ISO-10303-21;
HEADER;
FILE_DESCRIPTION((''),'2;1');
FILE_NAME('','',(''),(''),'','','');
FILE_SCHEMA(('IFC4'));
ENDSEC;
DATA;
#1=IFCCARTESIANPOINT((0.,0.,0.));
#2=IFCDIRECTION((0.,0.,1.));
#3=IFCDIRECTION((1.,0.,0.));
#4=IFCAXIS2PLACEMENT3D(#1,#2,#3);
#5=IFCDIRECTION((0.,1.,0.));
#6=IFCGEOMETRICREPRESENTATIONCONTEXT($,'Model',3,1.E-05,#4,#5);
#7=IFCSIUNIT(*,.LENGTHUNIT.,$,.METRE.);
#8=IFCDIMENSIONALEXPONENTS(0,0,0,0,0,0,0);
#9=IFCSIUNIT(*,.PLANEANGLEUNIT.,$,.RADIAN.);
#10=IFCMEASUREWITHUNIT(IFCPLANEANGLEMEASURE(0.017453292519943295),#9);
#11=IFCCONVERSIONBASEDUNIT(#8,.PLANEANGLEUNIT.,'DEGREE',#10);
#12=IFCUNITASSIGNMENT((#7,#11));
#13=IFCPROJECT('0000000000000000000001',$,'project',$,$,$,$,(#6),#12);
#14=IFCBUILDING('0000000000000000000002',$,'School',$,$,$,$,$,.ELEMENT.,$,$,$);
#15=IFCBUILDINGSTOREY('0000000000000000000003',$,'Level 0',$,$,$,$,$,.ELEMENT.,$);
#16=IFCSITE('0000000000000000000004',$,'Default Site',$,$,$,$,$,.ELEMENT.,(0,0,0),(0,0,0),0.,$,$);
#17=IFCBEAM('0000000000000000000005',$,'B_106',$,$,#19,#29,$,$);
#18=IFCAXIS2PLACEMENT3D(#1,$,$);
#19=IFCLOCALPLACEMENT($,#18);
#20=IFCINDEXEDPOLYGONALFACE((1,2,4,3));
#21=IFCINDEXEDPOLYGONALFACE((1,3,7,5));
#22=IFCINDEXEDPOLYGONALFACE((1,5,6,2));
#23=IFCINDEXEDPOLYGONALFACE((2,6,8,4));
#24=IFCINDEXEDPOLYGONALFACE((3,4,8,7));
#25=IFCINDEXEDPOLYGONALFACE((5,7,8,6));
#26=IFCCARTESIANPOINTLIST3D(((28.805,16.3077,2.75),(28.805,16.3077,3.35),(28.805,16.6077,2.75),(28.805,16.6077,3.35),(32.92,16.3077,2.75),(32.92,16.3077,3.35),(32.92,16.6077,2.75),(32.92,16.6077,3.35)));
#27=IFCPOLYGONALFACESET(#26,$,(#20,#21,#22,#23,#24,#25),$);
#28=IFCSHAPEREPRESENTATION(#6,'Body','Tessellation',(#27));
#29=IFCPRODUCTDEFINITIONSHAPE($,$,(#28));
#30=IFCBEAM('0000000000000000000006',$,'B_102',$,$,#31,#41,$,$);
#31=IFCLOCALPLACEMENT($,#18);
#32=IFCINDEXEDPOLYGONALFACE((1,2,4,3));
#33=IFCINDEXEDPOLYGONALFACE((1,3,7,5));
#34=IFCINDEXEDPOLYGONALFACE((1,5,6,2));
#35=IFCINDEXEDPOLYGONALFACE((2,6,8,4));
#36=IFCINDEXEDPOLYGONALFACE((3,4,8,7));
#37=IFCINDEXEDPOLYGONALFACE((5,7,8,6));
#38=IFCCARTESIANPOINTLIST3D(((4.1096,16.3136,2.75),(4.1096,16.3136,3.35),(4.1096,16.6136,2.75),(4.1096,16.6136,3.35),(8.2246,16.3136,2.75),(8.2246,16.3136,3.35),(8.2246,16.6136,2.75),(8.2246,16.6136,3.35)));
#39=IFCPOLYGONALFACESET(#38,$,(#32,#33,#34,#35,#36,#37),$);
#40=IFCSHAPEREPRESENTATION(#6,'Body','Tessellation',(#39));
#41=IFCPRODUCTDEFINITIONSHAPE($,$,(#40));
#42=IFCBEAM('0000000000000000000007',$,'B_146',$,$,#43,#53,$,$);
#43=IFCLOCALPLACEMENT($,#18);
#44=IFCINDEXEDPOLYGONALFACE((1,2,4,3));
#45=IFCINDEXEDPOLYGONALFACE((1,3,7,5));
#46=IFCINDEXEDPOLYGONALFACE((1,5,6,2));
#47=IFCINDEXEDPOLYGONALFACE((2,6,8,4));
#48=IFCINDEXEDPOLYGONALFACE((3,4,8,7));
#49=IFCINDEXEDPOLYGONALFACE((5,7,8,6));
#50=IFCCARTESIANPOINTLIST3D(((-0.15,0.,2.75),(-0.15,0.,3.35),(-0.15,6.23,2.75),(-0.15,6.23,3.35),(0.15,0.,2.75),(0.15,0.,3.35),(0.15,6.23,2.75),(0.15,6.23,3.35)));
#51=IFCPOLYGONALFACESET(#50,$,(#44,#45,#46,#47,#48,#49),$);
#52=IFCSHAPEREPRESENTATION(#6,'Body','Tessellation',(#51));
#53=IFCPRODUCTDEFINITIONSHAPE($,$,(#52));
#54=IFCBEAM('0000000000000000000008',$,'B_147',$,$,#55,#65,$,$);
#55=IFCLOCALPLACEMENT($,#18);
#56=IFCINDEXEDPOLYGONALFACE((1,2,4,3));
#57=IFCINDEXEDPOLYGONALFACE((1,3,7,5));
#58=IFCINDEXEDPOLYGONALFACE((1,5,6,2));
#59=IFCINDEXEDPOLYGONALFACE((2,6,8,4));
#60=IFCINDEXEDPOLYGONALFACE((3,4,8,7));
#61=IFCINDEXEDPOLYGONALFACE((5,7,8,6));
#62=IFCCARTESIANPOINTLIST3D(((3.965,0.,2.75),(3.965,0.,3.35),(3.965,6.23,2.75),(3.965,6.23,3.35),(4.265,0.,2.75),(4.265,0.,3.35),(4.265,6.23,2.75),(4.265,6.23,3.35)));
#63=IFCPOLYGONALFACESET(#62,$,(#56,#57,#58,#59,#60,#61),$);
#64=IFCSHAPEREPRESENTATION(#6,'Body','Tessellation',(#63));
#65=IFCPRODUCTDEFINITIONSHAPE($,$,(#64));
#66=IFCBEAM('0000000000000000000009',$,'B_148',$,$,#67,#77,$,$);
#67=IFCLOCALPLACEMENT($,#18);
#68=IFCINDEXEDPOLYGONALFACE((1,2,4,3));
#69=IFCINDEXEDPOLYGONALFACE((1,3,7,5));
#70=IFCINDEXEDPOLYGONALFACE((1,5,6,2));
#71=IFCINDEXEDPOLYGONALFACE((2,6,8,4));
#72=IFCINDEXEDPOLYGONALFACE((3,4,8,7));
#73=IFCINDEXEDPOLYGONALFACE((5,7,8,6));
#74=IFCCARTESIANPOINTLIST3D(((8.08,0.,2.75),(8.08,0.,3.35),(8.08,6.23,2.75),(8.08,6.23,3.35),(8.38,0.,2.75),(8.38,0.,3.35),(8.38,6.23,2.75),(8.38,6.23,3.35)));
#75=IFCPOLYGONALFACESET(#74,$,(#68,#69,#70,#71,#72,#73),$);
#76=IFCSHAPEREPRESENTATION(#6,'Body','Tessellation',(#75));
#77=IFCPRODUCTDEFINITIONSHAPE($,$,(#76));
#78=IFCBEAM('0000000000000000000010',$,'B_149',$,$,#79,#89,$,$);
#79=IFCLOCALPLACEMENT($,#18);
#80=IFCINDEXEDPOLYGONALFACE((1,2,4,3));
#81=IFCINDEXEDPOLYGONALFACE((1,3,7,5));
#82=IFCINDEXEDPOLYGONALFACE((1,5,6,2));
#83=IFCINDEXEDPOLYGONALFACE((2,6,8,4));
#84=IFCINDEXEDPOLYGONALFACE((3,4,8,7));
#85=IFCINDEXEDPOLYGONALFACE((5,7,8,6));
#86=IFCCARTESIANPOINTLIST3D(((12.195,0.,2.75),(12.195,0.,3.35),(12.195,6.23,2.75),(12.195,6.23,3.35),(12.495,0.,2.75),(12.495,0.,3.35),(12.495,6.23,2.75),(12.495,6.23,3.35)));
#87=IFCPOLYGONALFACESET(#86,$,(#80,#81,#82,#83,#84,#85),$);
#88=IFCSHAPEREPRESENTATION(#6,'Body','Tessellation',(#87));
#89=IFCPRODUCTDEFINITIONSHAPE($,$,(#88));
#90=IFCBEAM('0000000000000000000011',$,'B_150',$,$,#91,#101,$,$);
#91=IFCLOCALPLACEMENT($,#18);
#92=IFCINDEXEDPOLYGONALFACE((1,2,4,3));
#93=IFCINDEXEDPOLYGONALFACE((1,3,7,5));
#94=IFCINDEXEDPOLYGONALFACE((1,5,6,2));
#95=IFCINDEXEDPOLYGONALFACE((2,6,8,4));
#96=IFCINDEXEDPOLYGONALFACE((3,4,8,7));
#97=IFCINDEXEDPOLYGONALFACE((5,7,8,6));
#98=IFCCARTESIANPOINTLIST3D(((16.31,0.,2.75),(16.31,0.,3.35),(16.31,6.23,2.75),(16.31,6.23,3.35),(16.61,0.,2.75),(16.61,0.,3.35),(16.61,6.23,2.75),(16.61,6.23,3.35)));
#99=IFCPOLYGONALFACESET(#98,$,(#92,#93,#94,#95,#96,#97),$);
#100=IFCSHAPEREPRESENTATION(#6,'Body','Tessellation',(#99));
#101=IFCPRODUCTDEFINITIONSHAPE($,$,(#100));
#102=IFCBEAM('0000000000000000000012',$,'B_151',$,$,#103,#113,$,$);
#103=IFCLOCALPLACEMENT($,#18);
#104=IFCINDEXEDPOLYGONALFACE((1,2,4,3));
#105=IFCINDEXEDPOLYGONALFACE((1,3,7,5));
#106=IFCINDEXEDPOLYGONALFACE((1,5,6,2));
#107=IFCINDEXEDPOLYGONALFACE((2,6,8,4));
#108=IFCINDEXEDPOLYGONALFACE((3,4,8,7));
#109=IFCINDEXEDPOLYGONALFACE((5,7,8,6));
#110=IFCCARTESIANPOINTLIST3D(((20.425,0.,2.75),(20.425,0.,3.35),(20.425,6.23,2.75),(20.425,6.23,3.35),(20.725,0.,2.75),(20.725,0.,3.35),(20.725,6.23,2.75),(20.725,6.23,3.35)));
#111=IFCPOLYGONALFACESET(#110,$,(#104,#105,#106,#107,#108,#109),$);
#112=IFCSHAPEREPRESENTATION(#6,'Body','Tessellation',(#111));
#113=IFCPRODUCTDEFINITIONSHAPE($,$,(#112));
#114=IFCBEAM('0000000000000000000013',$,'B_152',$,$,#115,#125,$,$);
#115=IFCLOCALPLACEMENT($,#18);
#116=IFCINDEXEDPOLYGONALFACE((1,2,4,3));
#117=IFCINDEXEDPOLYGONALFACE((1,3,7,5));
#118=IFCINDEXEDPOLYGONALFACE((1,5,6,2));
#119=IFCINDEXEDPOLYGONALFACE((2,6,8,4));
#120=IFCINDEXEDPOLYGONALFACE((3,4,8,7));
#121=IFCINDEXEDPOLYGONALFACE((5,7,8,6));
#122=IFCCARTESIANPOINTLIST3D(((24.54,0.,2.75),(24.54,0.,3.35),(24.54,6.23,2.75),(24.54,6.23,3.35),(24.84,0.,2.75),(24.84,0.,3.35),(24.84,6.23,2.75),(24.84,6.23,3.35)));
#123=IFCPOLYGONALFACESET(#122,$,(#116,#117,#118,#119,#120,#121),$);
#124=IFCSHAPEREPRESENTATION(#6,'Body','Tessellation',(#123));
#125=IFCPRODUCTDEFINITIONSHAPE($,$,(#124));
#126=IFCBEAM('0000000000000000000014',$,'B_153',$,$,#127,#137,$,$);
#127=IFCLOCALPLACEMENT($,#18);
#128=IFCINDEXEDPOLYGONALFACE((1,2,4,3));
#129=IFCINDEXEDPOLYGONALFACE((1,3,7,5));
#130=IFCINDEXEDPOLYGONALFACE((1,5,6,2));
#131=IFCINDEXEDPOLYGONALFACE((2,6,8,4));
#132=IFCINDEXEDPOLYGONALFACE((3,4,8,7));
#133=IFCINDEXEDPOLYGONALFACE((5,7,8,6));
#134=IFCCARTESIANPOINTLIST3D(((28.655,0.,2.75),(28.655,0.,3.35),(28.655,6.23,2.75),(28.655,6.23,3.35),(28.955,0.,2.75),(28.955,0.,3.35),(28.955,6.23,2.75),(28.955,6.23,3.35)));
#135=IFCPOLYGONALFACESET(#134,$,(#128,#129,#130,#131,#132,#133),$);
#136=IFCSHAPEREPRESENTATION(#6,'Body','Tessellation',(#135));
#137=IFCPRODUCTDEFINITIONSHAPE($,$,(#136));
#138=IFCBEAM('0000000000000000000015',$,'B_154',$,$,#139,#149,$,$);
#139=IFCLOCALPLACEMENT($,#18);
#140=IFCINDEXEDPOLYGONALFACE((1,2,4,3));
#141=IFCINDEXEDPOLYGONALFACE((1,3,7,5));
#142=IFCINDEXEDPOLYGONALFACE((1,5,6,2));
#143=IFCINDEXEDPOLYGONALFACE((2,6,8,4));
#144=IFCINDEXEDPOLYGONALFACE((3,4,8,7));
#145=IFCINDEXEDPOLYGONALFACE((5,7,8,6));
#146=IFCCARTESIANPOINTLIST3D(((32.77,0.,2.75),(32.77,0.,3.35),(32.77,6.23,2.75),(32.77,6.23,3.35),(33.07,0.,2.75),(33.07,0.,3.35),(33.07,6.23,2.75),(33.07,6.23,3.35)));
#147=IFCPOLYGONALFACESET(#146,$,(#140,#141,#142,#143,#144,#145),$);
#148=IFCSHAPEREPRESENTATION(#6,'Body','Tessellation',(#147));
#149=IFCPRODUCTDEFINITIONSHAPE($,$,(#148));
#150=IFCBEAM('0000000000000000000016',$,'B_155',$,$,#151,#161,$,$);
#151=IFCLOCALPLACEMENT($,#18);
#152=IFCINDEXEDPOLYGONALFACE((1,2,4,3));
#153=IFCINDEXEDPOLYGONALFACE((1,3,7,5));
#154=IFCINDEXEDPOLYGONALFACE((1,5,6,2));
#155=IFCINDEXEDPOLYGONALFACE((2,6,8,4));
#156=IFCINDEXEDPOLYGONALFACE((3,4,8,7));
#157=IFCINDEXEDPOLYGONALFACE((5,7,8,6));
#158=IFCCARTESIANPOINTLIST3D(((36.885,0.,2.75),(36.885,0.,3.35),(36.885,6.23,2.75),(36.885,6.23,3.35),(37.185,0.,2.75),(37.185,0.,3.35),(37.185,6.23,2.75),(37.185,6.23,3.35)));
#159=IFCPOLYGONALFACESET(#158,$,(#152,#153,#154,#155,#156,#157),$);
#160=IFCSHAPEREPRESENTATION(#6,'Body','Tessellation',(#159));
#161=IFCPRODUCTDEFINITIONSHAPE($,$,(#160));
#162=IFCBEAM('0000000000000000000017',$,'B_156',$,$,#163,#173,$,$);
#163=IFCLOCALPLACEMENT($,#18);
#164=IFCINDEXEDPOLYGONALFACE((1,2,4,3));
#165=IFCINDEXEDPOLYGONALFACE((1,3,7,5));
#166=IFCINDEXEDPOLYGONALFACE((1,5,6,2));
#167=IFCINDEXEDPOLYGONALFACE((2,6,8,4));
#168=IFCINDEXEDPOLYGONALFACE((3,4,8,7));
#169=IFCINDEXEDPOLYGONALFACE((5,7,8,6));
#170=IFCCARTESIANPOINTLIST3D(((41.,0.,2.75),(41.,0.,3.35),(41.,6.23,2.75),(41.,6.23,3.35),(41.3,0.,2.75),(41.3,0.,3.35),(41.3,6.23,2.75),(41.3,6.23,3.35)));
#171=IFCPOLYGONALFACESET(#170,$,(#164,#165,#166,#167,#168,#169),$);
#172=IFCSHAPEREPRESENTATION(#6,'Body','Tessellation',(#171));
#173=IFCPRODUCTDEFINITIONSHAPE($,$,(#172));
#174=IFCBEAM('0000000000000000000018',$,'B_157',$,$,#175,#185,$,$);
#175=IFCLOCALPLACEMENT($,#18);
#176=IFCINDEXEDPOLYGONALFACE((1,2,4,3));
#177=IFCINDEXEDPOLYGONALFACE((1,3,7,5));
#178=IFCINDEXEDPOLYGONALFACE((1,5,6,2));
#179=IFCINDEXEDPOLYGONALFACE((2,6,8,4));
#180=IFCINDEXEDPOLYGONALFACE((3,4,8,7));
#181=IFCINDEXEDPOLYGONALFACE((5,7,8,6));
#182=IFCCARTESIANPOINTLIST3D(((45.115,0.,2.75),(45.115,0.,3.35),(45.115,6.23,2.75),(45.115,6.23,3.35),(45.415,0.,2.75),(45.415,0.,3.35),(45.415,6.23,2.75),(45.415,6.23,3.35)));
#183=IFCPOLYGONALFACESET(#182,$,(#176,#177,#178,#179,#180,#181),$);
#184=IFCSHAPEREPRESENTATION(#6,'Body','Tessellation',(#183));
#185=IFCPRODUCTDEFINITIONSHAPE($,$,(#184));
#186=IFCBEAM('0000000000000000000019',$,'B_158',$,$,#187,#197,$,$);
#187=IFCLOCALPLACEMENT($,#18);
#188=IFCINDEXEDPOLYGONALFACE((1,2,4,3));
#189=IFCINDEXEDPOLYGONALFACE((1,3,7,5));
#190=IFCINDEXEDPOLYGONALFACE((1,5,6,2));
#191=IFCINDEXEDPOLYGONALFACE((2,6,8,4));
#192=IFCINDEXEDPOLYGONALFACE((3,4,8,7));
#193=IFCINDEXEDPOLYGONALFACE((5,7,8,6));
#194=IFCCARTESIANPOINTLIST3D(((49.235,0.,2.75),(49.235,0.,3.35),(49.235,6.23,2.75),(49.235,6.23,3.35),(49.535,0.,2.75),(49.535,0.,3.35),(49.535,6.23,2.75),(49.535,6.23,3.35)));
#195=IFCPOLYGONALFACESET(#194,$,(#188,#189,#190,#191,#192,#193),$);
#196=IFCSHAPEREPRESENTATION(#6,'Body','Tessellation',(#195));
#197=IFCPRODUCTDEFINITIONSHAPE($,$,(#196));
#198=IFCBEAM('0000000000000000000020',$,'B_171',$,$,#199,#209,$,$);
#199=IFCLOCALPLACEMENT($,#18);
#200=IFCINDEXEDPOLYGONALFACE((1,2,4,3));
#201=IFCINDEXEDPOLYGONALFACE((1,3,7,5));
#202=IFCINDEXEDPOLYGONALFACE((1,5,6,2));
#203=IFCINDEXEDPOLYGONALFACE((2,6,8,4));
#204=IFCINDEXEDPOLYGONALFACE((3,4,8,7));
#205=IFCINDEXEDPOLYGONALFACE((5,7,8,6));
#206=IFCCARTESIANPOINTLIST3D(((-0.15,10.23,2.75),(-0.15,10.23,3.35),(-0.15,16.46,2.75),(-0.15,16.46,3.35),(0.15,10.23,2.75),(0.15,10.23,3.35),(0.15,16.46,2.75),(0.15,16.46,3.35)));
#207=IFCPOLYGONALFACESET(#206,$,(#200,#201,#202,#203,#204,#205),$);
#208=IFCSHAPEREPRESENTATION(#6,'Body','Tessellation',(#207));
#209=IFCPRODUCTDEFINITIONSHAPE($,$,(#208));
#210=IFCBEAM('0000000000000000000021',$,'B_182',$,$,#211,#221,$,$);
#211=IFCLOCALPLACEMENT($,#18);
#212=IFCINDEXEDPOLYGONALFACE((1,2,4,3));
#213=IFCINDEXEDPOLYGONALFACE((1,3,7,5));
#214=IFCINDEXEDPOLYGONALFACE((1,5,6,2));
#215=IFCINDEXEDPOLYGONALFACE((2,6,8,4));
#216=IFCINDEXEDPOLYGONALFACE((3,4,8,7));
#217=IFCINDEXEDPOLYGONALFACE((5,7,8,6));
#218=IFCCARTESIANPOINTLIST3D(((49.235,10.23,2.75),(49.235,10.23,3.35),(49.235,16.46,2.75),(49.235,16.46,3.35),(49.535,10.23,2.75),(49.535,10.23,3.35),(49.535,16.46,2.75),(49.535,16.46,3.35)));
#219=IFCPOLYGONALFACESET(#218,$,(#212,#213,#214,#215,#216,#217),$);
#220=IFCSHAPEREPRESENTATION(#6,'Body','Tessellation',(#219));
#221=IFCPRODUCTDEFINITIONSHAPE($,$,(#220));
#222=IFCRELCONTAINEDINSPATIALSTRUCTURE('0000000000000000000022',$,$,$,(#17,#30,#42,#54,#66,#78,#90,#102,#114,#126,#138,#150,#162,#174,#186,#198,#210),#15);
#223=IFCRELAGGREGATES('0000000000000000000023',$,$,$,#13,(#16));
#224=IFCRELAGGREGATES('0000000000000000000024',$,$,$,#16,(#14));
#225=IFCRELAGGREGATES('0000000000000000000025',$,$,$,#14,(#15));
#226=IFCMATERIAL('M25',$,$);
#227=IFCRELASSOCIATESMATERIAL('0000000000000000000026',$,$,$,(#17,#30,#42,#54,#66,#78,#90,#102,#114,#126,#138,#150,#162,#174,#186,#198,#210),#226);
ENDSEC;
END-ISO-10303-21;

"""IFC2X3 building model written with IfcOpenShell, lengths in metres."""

from ifc_helpers import new_model, entity, si_unit, converted_unit, direction, frame, frame_2d, origin_with_axes, place, context, project, spatial, rectangle, extrude, material, element, save


model = new_model("IFC2X3")

# Units and contexts
model_context = context("Model", 3, precision=1e-05, world=origin_with_axes(), true_north=direction((0.0, 1.0, 0.0)))
ifc_project = project(units=[si_unit("LENGTHUNIT", "METRE"), converted_unit("PLANEANGLEUNIT", "DEGREE", entity("IfcPlaneAngleMeasure", 0.017453292519943295), si_unit("PLANEANGLEUNIT", "RADIAN"), dimensions=[0, 0, 0, 0, 0, 0, 0])], contexts=[model_context])

# Site, building, storey
site = spatial("IfcSite", under=ifc_project, Name="Default Site", CompositionType="ELEMENT", RefLatitude=(0, 0, 0), RefLongitude=(0, 0, 0), RefElevation=0.0)
building = spatial("IfcBuilding", under=site, Name="School", CompositionType="ELEMENT")
storey = spatial("IfcBuildingStorey", under=building, Name="Level 0", CompositionType="ELEMENT")

# Beams
ifc_material = material(Name="M25")
placement = place(None, origin_with_axes())
element("IfcBeam", 1, at=placement, inside=storey, material=ifc_material, Name="B_106", context=model_context, shape_type="SweptSolid", body=[
    extrude(rectangle(XDim=0.3, YDim=0.6, at=frame_2d((0.0, 0.0), x_axis=(0.0, 1.0, 0.0))), frame((28.805, 16.4577, 3.05), z_axis=(1.0, 0.0, 0.0), x_axis=(0.0, 0.0, -1.0)), (0.0, 0.0, 1.0), 4.115),
])
element("IfcBeam", 2, at=placement, inside=storey, material=ifc_material, Name="B_102", context=model_context, shape_type="SweptSolid", body=[
    extrude(rectangle(XDim=0.3, YDim=0.6, at=frame_2d((0.0, 0.0), x_axis=(0.0, 1.0, 0.0))), frame((4.1096, 16.4636, 3.05), z_axis=(1.0, 0.0, 0.0), x_axis=(0.0, 0.0, -1.0)), (0.0, 0.0, 1.0), 4.115),
])
element("IfcBeam", 3, at=placement, inside=storey, material=ifc_material, Name="B_146", context=model_context, shape_type="SweptSolid", body=[
    extrude(rectangle(XDim=0.3, YDim=0.6, at=frame_2d((0.0, 0.0), x_axis=(0.0, 1.0, 0.0))), frame((0.0, 0.0, 3.05), z_axis=(0.0, 1.0, 0.0), x_axis=(0.0, 0.0, -1.0)), (0.0, 0.0, 1.0), 6.23),
])
element("IfcBeam", 4, at=placement, inside=storey, material=ifc_material, Name="B_147", context=model_context, shape_type="SweptSolid", body=[
    extrude(rectangle(XDim=0.3, YDim=0.6, at=frame_2d((0.0, 0.0), x_axis=(0.0, 1.0, 0.0))), frame((4.115, 0.0, 3.05), z_axis=(0.0, 1.0, 0.0), x_axis=(0.0, 0.0, -1.0)), (0.0, 0.0, 1.0), 6.23),
])
element("IfcBeam", 5, at=placement, inside=storey, material=ifc_material, Name="B_148", context=model_context, shape_type="SweptSolid", body=[
    extrude(rectangle(XDim=0.3, YDim=0.6, at=frame_2d((0.0, 0.0), x_axis=(0.0, 1.0, 0.0))), frame((8.23, 0.0, 3.05), z_axis=(0.0, 1.0, 0.0), x_axis=(0.0, 0.0, -1.0)), (0.0, 0.0, 1.0), 6.23),
])
element("IfcBeam", 6, at=placement, inside=storey, material=ifc_material, Name="B_149", context=model_context, shape_type="SweptSolid", body=[
    extrude(rectangle(XDim=0.3, YDim=0.6, at=frame_2d((0.0, 0.0), x_axis=(0.0, 1.0, 0.0))), frame((12.345, 0.0, 3.05), z_axis=(0.0, 1.0, 0.0), x_axis=(0.0, 0.0, -1.0)), (0.0, 0.0, 1.0), 6.23),
])
element("IfcBeam", 7, at=placement, inside=storey, material=ifc_material, Name="B_150", context=model_context, shape_type="SweptSolid", body=[
    extrude(rectangle(XDim=0.3, YDim=0.6, at=frame_2d((0.0, 0.0), x_axis=(0.0, 1.0, 0.0))), frame((16.46, 0.0, 3.05), z_axis=(0.0, 1.0, 0.0), x_axis=(0.0, 0.0, -1.0)), (0.0, 0.0, 1.0), 6.23),
])
element("IfcBeam", 8, at=placement, inside=storey, material=ifc_material, Name="B_151", context=model_context, shape_type="SweptSolid", body=[
    extrude(rectangle(XDim=0.3, YDim=0.6, at=frame_2d((0.0, 0.0), x_axis=(0.0, 1.0, 0.0))), frame((20.575, 0.0, 3.05), z_axis=(0.0, 1.0, 0.0), x_axis=(0.0, 0.0, -1.0)), (0.0, 0.0, 1.0), 6.23),
])
element("IfcBeam", 9, at=placement, inside=storey, material=ifc_material, Name="B_152", context=model_context, shape_type="SweptSolid", body=[
    extrude(rectangle(XDim=0.3, YDim=0.6, at=frame_2d((0.0, 0.0), x_axis=(0.0, 1.0, 0.0))), frame((24.69, 0.0, 3.05), z_axis=(0.0, 1.0, 0.0), x_axis=(0.0, 0.0, -1.0)), (0.0, 0.0, 1.0), 6.23),
])
element("IfcBeam", 10, at=placement, inside=storey, material=ifc_material, Name="B_153", context=model_context, shape_type="SweptSolid", body=[
    extrude(rectangle(XDim=0.3, YDim=0.6, at=frame_2d((0.0, 0.0), x_axis=(0.0, 1.0, 0.0))), frame((28.805, 0.0, 3.05), z_axis=(0.0, 1.0, 0.0), x_axis=(0.0, 0.0, -1.0)), (0.0, 0.0, 1.0), 6.23),
])
element("IfcBeam", 11, at=placement, inside=storey, material=ifc_material, Name="B_154", context=model_context, shape_type="SweptSolid", body=[
    extrude(rectangle(XDim=0.3, YDim=0.6, at=frame_2d((0.0, 0.0), x_axis=(0.0, 1.0, 0.0))), frame((32.92, 0.0, 3.05), z_axis=(0.0, 1.0, 0.0), x_axis=(0.0, 0.0, -1.0)), (0.0, 0.0, 1.0), 6.23),
])
element("IfcBeam", 12, at=placement, inside=storey, material=ifc_material, Name="B_155", context=model_context, shape_type="SweptSolid", body=[
    extrude(rectangle(XDim=0.3, YDim=0.6, at=frame_2d((0.0, 0.0), x_axis=(0.0, 1.0, 0.0))), frame((37.035, 0.0, 3.05), z_axis=(0.0, 1.0, 0.0), x_axis=(0.0, 0.0, -1.0)), (0.0, 0.0, 1.0), 6.23),
])
element("IfcBeam", 13, at=placement, inside=storey, material=ifc_material, Name="B_156", context=model_context, shape_type="SweptSolid", body=[
    extrude(rectangle(XDim=0.3, YDim=0.6, at=frame_2d((0.0, 0.0), x_axis=(0.0, 1.0, 0.0))), frame((41.15, 0.0, 3.05), z_axis=(0.0, 1.0, 0.0), x_axis=(0.0, 0.0, -1.0)), (0.0, 0.0, 1.0), 6.23),
])
element("IfcBeam", 14, at=placement, inside=storey, material=ifc_material, Name="B_157", context=model_context, shape_type="SweptSolid", body=[
    extrude(rectangle(XDim=0.3, YDim=0.6, at=frame_2d((0.0, 0.0), x_axis=(0.0, 1.0, 0.0))), frame((45.265, 0.0, 3.05), z_axis=(0.0, 1.0, 0.0), x_axis=(0.0, 0.0, -1.0)), (0.0, 0.0, 1.0), 6.23),
])
element("IfcBeam", 15, at=placement, inside=storey, material=ifc_material, Name="B_158", context=model_context, shape_type="SweptSolid", body=[
    extrude(rectangle(XDim=0.3, YDim=0.6, at=frame_2d((0.0, 0.0), x_axis=(0.0, 1.0, 0.0))), frame((49.385, 0.0, 3.05), z_axis=(0.0, 1.0, 0.0), x_axis=(0.0, 0.0, -1.0)), (0.0, 0.0, 1.0), 6.23),
])
element("IfcBeam", 16, at=placement, inside=storey, material=ifc_material, Name="B_171", context=model_context, shape_type="SweptSolid", body=[
    extrude(rectangle(XDim=0.3, YDim=0.6, at=frame_2d((0.0, 0.0), x_axis=(0.0, 1.0, 0.0))), frame((0.0, 10.23, 3.05), z_axis=(0.0, 1.0, 0.0), x_axis=(0.0, 0.0, -1.0)), (0.0, 0.0, 1.0), 6.23),
])
element("IfcBeam", 17, at=placement, inside=storey, material=ifc_material, Name="B_182", context=model_context, shape_type="SweptSolid", body=[
    extrude(rectangle(XDim=0.3, YDim=0.6, at=frame_2d((0.0, 0.0), x_axis=(0.0, 1.0, 0.0))), frame((49.385, 10.23, 3.05), z_axis=(0.0, 1.0, 0.0), x_axis=(0.0, 0.0, -1.0)), (0.0, 0.0, 1.0), 6.23),
])

save(model, "model.ifc")
